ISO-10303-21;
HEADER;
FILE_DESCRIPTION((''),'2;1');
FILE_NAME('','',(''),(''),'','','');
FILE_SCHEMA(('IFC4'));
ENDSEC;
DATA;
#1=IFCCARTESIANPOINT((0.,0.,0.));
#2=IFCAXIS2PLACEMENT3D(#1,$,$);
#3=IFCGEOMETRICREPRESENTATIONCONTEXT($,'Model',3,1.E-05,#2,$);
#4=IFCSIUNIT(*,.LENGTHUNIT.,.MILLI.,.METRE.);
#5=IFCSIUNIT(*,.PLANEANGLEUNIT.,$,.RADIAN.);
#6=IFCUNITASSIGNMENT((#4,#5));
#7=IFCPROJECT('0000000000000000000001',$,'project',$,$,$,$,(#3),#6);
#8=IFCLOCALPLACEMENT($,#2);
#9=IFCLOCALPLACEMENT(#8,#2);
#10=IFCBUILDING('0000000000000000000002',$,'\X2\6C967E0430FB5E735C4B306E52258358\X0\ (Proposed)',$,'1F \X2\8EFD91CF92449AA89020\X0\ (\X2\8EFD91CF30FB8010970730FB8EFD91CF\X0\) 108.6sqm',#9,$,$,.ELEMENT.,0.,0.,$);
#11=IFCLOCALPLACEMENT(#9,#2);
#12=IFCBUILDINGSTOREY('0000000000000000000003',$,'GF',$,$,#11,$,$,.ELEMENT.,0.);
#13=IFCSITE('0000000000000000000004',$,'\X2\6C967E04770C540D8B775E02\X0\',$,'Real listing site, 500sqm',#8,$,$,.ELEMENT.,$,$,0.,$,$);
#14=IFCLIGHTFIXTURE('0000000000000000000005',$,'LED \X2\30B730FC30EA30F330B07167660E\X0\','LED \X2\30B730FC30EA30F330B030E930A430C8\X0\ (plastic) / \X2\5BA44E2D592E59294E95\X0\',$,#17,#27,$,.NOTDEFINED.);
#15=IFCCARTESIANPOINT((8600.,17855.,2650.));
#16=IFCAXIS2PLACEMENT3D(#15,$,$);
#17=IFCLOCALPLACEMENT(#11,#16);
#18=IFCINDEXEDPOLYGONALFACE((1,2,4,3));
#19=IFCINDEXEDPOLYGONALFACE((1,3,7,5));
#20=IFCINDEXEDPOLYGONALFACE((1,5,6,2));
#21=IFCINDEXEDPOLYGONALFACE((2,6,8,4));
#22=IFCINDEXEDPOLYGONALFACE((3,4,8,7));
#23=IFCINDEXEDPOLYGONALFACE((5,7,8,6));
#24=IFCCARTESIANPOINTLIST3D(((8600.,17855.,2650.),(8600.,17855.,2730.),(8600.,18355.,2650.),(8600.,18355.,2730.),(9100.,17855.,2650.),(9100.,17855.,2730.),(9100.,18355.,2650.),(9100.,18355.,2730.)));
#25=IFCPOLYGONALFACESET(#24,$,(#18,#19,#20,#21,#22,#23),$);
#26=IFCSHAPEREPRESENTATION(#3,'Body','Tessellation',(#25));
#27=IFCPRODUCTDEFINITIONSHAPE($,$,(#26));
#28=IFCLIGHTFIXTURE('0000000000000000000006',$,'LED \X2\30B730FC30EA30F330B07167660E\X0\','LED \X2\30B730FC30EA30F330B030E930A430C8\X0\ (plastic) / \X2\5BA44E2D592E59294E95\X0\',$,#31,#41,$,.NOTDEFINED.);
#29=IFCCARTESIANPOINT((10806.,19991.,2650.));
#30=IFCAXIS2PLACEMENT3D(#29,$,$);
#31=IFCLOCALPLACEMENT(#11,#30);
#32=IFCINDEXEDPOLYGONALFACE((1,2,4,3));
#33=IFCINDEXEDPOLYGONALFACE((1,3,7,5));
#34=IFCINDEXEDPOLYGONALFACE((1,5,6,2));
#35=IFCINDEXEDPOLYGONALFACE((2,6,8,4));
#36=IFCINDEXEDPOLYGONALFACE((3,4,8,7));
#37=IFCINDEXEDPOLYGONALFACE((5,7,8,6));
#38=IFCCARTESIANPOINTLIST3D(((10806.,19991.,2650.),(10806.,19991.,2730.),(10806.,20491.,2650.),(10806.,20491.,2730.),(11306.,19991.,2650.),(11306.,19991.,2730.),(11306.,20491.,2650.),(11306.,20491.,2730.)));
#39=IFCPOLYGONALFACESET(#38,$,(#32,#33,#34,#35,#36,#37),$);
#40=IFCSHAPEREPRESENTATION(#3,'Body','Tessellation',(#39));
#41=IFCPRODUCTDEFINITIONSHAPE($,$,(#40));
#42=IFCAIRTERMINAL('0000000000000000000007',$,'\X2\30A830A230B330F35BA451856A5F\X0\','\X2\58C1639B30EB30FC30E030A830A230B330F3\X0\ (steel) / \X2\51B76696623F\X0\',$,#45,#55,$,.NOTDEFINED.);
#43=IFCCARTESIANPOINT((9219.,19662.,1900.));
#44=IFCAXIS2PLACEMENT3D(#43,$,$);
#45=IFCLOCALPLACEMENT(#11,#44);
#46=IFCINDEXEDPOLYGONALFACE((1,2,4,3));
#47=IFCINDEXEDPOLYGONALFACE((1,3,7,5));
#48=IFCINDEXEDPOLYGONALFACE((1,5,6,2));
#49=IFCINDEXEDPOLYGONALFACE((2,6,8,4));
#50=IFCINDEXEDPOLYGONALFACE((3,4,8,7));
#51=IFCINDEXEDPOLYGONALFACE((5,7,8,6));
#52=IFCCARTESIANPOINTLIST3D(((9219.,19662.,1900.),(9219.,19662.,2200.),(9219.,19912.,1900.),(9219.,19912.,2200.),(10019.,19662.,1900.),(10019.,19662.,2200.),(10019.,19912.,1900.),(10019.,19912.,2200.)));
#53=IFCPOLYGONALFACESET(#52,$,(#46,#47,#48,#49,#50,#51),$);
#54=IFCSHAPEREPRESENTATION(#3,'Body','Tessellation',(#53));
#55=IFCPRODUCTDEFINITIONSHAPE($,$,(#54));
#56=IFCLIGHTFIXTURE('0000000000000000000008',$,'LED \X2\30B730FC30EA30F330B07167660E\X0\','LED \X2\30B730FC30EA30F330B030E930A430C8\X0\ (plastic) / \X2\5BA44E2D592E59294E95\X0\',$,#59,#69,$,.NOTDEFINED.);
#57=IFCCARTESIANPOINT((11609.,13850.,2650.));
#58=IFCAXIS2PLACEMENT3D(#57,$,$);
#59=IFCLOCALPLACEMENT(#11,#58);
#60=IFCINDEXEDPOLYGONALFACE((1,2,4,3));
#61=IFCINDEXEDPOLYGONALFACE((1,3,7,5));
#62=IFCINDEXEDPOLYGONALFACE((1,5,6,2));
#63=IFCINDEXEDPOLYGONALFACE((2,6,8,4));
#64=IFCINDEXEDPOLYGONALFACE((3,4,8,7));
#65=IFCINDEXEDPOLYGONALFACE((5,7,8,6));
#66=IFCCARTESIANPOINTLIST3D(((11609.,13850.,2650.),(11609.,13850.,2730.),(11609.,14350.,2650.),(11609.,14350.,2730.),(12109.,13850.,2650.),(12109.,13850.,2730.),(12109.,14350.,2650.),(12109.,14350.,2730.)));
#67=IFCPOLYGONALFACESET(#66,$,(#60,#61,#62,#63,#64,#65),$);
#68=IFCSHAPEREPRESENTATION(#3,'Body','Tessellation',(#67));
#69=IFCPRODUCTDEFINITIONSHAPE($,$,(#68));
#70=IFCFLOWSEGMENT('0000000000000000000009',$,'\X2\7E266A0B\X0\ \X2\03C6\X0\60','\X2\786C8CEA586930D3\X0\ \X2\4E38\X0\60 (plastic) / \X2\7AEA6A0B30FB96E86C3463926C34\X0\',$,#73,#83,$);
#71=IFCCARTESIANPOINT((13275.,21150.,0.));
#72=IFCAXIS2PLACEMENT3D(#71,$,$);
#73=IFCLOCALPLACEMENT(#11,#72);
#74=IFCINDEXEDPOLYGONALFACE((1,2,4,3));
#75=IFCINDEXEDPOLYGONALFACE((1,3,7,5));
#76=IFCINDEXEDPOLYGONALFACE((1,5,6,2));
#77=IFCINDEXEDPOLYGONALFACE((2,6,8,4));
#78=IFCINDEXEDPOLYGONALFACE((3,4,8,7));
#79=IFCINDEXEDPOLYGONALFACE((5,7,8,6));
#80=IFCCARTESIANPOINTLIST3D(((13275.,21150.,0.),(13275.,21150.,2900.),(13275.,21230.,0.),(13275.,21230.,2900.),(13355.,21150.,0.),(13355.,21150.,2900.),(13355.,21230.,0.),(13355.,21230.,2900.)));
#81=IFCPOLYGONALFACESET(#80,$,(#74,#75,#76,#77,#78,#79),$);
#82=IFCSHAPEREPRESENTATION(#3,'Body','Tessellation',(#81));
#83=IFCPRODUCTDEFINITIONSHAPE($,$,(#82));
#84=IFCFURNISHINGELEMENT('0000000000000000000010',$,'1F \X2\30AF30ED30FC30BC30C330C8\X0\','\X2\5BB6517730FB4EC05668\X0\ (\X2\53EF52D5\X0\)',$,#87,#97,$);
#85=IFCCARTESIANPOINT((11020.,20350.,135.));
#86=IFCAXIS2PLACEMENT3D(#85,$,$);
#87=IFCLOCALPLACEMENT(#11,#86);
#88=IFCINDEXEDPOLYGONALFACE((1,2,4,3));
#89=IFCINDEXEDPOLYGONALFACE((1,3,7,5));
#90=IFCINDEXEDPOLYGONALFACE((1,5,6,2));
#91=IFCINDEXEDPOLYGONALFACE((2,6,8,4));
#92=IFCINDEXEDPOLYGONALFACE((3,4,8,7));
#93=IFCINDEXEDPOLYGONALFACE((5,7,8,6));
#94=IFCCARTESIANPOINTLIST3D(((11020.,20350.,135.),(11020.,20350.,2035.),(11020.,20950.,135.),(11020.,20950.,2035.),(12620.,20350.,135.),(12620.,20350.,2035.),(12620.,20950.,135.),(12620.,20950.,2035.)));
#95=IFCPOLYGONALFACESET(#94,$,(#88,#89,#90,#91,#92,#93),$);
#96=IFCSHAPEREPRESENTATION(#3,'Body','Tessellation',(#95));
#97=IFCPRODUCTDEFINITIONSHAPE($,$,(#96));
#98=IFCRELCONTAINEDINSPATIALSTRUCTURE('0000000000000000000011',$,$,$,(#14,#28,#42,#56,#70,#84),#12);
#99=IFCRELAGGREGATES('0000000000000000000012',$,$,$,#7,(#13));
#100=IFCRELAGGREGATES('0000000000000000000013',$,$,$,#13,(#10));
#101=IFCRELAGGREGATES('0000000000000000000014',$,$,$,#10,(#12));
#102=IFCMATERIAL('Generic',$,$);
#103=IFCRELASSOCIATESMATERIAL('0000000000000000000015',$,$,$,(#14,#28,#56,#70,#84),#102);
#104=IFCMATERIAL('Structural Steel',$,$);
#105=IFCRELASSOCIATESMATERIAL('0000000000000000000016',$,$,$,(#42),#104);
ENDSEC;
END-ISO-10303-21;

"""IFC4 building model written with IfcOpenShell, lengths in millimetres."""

from ifc_helpers import new_model, si_unit, frame, frame_2d, origin, place, context, project, spatial, rectangle, extrude, material, element, save


model = new_model("IFC4")

# Units and contexts
model_context = context("Model", 3, precision=1e-05, world=origin())
ifc_project = project(units=[si_unit("LENGTHUNIT", "METRE", prefix="MILLI"), si_unit("PLANEANGLEUNIT", "RADIAN")], contexts=[model_context])

# Site, building, storey
site_placement = place(None, origin())
site = spatial("IfcSite", under=ifc_project, at=site_placement, Name="沖縄県名護市", ObjectType="Real listing site, 500sqm", CompositionType="ELEMENT", RefElevation=0.0)
building_placement = place(site_placement, origin())
building = spatial("IfcBuilding", under=site, at=building_placement, Name="沖縄・平屋の別荘 (Proposed)", ObjectType="1F 軽量鉄骨造 (軽量・耐震・軽量) 108.6sqm", CompositionType="ELEMENT", ElevationOfRefHeight=0.0, ElevationOfTerrain=0.0)
storey_placement = place(building_placement, origin())
storey = spatial("IfcBuildingStorey", under=building, at=storey_placement, Name="GF", CompositionType="ELEMENT", Elevation=0.0)

# Shared definitions
ifc_material_1 = material(Name="Generic")

# Shared definitions
ifc_material_2 = material(Name="Structural Steel")

# Light fixtures
light_fixture_1_placement = place(storey_placement, frame((8600.0, 17855.0, 2650.0)))
element("IfcLightFixture", 1, at=light_fixture_1_placement, inside=storey, material=ifc_material_1, Name="LED シーリング照明", Description="LED シーリングライト (plastic) / 室中央天井", PredefinedType="NOTDEFINED", context=model_context, shape_type="SweptSolid", body=[
    extrude(rectangle(XDim=500.0, YDim=500.0, at=frame_2d((250.0, 250.0))), frame((8600.0, 17855.0, 2650.0)), (0.0, 0.0, 1.0), 80.0),
])
light_fixture_2_placement = place(storey_placement, frame((10806.0, 19991.0, 2650.0)))
element("IfcLightFixture", 2, at=light_fixture_2_placement, inside=storey, material=ifc_material_1, Name="LED シーリング照明", Description="LED シーリングライト (plastic) / 室中央天井", PredefinedType="NOTDEFINED", context=model_context, shape_type="SweptSolid", body=[
    extrude(rectangle(XDim=500.0, YDim=500.0, at=frame_2d((250.0, 250.0))), frame((10806.0, 19991.0, 2650.0)), (0.0, 0.0, 1.0), 80.0),
])

# Air terminal
air_terminal_placement = place(storey_placement, frame((9219.0, 19662.0, 1900.0)))
element("IfcAirTerminal", 3, at=air_terminal_placement, inside=storey, material=ifc_material_2, Name="エアコン室内機", Description="壁掛ルームエアコン (steel) / 冷暖房", PredefinedType="NOTDEFINED", context=model_context, shape_type="SweptSolid", body=[
    extrude(rectangle(XDim=800.0, YDim=250.0, at=frame_2d((400.0, 125.0))), frame((9219.0, 19662.0, 1900.0)), (0.0, 0.0, 1.0), 300.0),
])

# Light fixture
light_fixture_3_placement = place(storey_placement, frame((11609.0, 13850.0, 2650.0)))
element("IfcLightFixture", 4, at=light_fixture_3_placement, inside=storey, material=ifc_material_1, Name="LED シーリング照明", Description="LED シーリングライト (plastic) / 室中央天井", PredefinedType="NOTDEFINED", context=model_context, shape_type="SweptSolid", body=[
    extrude(rectangle(XDim=500.0, YDim=500.0, at=frame_2d((250.0, 250.0))), frame((11609.0, 13850.0, 2650.0)), (0.0, 0.0, 1.0), 80.0),
])

# Flow segment
flow_segment_placement = place(storey_placement, frame((13275.0, 21150.0, 0.0)))
element("IfcFlowSegment", 5, at=flow_segment_placement, inside=storey, material=ifc_material_1, Name="縦樋 φ60", Description="硬質塩ビ 丸60 (plastic) / 竪樋・雨水排水", context=model_context, shape_type="SweptSolid", body=[
    extrude(rectangle(XDim=80.0, YDim=80.0, at=frame_2d((40.0, 40.0))), frame((13275.0, 21150.0, 0.0)), (0.0, 0.0, 1.0), 2900.0),
])

# Furnishing element
furnishing_placement = place(storey_placement, frame((11020.0, 20350.0, 135.0)))
element("IfcFurnishingElement", 6, at=furnishing_placement, inside=storey, material=ifc_material_1, Name="1F クローゼット", Description="家具・什器 (可動)", context=model_context, shape_type="SweptSolid", body=[
    extrude(rectangle(XDim=1600.0, YDim=600.0, at=frame_2d((800.0, 300.0))), frame((11020.0, 20350.0, 135.0)), (0.0, 0.0, 1.0), 1900.0),
])

save(model, "model.ifc")
